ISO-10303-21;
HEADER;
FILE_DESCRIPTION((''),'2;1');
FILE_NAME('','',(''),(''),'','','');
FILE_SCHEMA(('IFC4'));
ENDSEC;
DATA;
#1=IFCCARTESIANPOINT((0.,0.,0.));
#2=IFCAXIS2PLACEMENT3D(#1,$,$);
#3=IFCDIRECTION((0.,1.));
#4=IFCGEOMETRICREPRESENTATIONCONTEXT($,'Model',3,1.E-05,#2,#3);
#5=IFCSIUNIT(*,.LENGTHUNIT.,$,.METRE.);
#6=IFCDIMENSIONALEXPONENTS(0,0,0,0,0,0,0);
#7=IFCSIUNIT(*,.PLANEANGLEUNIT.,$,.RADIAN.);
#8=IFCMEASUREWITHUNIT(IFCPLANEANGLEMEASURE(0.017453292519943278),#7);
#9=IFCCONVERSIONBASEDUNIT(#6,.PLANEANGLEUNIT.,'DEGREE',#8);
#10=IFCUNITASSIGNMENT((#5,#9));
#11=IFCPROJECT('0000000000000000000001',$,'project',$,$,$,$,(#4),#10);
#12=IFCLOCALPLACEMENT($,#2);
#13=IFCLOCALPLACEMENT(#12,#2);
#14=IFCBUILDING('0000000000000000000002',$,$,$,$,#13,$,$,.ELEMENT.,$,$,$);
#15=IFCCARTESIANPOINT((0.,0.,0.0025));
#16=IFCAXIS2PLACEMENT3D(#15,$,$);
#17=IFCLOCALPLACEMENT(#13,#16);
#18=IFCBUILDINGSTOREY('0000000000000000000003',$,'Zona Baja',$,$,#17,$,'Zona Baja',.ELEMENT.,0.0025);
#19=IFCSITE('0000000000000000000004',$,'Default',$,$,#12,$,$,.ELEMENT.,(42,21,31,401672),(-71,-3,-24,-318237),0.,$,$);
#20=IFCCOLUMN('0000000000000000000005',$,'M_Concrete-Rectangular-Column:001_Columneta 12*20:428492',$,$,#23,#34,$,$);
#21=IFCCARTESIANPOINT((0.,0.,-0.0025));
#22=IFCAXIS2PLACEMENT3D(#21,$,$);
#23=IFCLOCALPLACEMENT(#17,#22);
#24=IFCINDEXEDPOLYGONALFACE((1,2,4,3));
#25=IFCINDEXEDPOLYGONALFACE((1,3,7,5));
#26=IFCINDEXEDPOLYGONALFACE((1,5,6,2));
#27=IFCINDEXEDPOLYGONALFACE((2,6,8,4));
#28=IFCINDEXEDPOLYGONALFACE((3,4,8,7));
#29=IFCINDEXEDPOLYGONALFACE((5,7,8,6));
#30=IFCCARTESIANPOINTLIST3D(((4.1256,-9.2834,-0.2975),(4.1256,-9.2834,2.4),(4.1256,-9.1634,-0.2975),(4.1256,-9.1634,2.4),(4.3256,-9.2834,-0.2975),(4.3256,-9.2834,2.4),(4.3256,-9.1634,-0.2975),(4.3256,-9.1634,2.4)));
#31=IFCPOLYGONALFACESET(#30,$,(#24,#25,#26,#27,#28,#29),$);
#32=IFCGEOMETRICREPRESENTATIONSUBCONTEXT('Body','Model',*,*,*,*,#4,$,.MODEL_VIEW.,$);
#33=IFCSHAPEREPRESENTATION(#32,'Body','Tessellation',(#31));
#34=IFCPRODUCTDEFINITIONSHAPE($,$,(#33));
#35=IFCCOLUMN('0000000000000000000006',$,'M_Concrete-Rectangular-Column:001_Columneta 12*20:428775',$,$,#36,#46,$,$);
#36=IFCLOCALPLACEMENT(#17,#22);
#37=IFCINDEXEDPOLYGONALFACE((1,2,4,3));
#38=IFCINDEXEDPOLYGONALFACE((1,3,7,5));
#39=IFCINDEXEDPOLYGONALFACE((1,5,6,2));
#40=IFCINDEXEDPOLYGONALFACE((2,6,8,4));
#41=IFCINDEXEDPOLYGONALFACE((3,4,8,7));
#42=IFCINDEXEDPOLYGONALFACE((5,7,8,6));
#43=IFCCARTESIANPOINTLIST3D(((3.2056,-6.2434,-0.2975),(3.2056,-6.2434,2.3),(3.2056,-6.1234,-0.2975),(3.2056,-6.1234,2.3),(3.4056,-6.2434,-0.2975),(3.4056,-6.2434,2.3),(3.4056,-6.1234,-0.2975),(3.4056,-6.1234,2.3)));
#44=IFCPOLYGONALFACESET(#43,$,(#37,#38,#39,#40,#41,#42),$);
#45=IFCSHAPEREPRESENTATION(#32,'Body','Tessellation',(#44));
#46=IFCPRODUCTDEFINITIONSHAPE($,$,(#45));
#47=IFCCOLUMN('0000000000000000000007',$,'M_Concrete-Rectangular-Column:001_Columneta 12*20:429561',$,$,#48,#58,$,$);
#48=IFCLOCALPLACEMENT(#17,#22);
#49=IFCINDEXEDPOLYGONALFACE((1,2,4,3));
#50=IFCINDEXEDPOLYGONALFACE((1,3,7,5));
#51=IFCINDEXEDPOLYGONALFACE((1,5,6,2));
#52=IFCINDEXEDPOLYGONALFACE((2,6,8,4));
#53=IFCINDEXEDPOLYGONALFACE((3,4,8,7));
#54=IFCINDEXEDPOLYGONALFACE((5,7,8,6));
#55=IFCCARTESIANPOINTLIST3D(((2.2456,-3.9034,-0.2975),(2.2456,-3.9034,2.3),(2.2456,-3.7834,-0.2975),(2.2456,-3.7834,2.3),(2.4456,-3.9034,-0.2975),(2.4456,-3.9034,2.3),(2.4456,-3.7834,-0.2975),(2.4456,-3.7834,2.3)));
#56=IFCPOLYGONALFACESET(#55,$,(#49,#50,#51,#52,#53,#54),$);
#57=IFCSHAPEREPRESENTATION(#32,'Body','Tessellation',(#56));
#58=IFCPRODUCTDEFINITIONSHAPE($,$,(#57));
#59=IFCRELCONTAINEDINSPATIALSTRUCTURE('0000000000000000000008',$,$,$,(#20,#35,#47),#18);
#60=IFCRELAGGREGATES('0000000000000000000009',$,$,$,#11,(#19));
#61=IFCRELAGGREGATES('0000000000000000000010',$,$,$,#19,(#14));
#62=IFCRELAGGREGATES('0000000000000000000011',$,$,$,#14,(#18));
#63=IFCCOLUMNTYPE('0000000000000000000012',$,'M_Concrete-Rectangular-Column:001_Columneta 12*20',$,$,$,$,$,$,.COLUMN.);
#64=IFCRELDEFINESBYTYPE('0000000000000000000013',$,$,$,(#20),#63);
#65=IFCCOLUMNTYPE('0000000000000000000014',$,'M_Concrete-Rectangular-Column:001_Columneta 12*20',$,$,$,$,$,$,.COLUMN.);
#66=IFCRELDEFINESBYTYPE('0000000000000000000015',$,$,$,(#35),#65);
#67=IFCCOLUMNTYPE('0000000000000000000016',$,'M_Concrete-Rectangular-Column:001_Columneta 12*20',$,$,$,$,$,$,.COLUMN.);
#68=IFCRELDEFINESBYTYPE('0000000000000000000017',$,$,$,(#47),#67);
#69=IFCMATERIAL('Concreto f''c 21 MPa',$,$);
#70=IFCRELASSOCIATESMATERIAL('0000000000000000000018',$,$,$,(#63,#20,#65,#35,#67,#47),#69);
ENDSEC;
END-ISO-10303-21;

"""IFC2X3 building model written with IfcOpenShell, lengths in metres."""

from ifc_helpers import new_model, entity, si_unit, converted_unit, direction, frame, frame_2d, origin, place, context, subcontext, project, spatial, rectangle, extrude, source, transform, mapped, material, type_object, type_shapes, element, save


model = new_model("IFC2X3")

# Units and contexts
model_context = context("Model", 3, precision=1e-05, world=origin(), true_north=direction((0.0, 1.0)))
body_context = subcontext(model_context, "Body", "Model", "MODEL_VIEW")
ifc_project = project(units=[si_unit("LENGTHUNIT", "METRE"), converted_unit("PLANEANGLEUNIT", "DEGREE", entity("IfcPlaneAngleMeasure", 0.017453292519943278), si_unit("PLANEANGLEUNIT", "RADIAN"), dimensions=[0, 0, 0, 0, 0, 0, 0])], contexts=[model_context])

# Site, building, storey
site_placement = place(None, origin())
site = spatial("IfcSite", under=ifc_project, at=site_placement, Name="Default", CompositionType="ELEMENT", RefLatitude=(42, 21, 31, 401672), RefLongitude=(-71, -3, -24, -318237), RefElevation=0.0)
building_placement = place(site_placement, origin())
building = spatial("IfcBuilding", under=site, at=building_placement, CompositionType="ELEMENT")
storey_placement = place(building_placement, frame((0.0, 0.0, 0.0025)))
storey = spatial("IfcBuildingStorey", under=building, at=storey_placement, Name="Zona Baja", LongName="Zona Baja", CompositionType="ELEMENT", Elevation=0.0025)

# Columns
ifc_material_1 = material(Name="Concreto f'c 21 MPa")
column_type_1 = type_object("IfcColumnType", Name="M_Concrete-Rectangular-Column:001_Columneta 12*20", PredefinedType="COLUMN", material=ifc_material_1)
shared_shape_1 = source(origin(), body_context, "Body", "SweptSolid", [
    extrude(rectangle(XDim=0.12, YDim=0.2, at=frame_2d((0.0, 0.0), x_axis=(1.0, 0.0))), frame((4.2256, -9.2234, -0.2975), z_axis=(0.0, 0.0, 1.0), x_axis=(0.0, -1.0, 0.0)), (0.0, 0.0, 1.0), 2.6975),
])
type_shapes(column_type_1, [shared_shape_1])
column_1_placement = place(storey_placement, frame((0.0, 0.0, -0.0025)))
element("IfcColumn", 1, at=column_1_placement, inside=storey, type_object=column_type_1, material=ifc_material_1, Name="M_Concrete-Rectangular-Column:001_Columneta 12*20:428492", context=body_context, shape_type="MappedRepresentation", body=[
    mapped(shared_shape_1, transform((0.0, 0.0, 0.0), scale=1.0)),
])
column_type_2 = type_object("IfcColumnType", Name="M_Concrete-Rectangular-Column:001_Columneta 12*20", PredefinedType="COLUMN", material=ifc_material_1)
shared_shape_2 = source(origin(), body_context, "Body", "SweptSolid", [
    extrude(rectangle(XDim=0.12, YDim=0.2, at=frame_2d((0.0, 0.0), x_axis=(1.0, 0.0))), frame((3.3056, -6.1834, -0.2975), z_axis=(0.0, 0.0, 1.0), x_axis=(0.0, -1.0, 0.0)), (0.0, 0.0, 1.0), 2.5975),
])
type_shapes(column_type_2, [shared_shape_2])
column_2_placement = place(storey_placement, frame((0.0, 0.0, -0.0025)))
element("IfcColumn", 2, at=column_2_placement, inside=storey, type_object=column_type_2, material=ifc_material_1, Name="M_Concrete-Rectangular-Column:001_Columneta 12*20:428775", context=body_context, shape_type="MappedRepresentation", body=[
    mapped(shared_shape_2, transform((0.0, 0.0, 0.0), scale=1.0)),
])
column_type_3 = type_object("IfcColumnType", Name="M_Concrete-Rectangular-Column:001_Columneta 12*20", PredefinedType="COLUMN", material=ifc_material_1)
shared_shape_3 = source(origin(), body_context, "Body", "SweptSolid", [
    extrude(rectangle(XDim=0.12, YDim=0.2, at=frame_2d((0.0, 0.0), x_axis=(1.0, 0.0))), frame((2.3456, -3.8434, -0.2975), z_axis=(0.0, 0.0, 1.0), x_axis=(0.0, 1.0, 0.0)), (0.0, 0.0, 1.0), 2.5975),
])
type_shapes(column_type_3, [shared_shape_3])
column_3_placement = place(storey_placement, frame((0.0, 0.0, -0.0025)))
element("IfcColumn", 3, at=column_3_placement, inside=storey, type_object=column_type_3, material=ifc_material_1, Name="M_Concrete-Rectangular-Column:001_Columneta 12*20:429561", context=body_context, shape_type="MappedRepresentation", body=[
    mapped(shared_shape_3, transform((0.0, 0.0, 0.0), scale=1.0)),
])

save(model, "model.ifc")
